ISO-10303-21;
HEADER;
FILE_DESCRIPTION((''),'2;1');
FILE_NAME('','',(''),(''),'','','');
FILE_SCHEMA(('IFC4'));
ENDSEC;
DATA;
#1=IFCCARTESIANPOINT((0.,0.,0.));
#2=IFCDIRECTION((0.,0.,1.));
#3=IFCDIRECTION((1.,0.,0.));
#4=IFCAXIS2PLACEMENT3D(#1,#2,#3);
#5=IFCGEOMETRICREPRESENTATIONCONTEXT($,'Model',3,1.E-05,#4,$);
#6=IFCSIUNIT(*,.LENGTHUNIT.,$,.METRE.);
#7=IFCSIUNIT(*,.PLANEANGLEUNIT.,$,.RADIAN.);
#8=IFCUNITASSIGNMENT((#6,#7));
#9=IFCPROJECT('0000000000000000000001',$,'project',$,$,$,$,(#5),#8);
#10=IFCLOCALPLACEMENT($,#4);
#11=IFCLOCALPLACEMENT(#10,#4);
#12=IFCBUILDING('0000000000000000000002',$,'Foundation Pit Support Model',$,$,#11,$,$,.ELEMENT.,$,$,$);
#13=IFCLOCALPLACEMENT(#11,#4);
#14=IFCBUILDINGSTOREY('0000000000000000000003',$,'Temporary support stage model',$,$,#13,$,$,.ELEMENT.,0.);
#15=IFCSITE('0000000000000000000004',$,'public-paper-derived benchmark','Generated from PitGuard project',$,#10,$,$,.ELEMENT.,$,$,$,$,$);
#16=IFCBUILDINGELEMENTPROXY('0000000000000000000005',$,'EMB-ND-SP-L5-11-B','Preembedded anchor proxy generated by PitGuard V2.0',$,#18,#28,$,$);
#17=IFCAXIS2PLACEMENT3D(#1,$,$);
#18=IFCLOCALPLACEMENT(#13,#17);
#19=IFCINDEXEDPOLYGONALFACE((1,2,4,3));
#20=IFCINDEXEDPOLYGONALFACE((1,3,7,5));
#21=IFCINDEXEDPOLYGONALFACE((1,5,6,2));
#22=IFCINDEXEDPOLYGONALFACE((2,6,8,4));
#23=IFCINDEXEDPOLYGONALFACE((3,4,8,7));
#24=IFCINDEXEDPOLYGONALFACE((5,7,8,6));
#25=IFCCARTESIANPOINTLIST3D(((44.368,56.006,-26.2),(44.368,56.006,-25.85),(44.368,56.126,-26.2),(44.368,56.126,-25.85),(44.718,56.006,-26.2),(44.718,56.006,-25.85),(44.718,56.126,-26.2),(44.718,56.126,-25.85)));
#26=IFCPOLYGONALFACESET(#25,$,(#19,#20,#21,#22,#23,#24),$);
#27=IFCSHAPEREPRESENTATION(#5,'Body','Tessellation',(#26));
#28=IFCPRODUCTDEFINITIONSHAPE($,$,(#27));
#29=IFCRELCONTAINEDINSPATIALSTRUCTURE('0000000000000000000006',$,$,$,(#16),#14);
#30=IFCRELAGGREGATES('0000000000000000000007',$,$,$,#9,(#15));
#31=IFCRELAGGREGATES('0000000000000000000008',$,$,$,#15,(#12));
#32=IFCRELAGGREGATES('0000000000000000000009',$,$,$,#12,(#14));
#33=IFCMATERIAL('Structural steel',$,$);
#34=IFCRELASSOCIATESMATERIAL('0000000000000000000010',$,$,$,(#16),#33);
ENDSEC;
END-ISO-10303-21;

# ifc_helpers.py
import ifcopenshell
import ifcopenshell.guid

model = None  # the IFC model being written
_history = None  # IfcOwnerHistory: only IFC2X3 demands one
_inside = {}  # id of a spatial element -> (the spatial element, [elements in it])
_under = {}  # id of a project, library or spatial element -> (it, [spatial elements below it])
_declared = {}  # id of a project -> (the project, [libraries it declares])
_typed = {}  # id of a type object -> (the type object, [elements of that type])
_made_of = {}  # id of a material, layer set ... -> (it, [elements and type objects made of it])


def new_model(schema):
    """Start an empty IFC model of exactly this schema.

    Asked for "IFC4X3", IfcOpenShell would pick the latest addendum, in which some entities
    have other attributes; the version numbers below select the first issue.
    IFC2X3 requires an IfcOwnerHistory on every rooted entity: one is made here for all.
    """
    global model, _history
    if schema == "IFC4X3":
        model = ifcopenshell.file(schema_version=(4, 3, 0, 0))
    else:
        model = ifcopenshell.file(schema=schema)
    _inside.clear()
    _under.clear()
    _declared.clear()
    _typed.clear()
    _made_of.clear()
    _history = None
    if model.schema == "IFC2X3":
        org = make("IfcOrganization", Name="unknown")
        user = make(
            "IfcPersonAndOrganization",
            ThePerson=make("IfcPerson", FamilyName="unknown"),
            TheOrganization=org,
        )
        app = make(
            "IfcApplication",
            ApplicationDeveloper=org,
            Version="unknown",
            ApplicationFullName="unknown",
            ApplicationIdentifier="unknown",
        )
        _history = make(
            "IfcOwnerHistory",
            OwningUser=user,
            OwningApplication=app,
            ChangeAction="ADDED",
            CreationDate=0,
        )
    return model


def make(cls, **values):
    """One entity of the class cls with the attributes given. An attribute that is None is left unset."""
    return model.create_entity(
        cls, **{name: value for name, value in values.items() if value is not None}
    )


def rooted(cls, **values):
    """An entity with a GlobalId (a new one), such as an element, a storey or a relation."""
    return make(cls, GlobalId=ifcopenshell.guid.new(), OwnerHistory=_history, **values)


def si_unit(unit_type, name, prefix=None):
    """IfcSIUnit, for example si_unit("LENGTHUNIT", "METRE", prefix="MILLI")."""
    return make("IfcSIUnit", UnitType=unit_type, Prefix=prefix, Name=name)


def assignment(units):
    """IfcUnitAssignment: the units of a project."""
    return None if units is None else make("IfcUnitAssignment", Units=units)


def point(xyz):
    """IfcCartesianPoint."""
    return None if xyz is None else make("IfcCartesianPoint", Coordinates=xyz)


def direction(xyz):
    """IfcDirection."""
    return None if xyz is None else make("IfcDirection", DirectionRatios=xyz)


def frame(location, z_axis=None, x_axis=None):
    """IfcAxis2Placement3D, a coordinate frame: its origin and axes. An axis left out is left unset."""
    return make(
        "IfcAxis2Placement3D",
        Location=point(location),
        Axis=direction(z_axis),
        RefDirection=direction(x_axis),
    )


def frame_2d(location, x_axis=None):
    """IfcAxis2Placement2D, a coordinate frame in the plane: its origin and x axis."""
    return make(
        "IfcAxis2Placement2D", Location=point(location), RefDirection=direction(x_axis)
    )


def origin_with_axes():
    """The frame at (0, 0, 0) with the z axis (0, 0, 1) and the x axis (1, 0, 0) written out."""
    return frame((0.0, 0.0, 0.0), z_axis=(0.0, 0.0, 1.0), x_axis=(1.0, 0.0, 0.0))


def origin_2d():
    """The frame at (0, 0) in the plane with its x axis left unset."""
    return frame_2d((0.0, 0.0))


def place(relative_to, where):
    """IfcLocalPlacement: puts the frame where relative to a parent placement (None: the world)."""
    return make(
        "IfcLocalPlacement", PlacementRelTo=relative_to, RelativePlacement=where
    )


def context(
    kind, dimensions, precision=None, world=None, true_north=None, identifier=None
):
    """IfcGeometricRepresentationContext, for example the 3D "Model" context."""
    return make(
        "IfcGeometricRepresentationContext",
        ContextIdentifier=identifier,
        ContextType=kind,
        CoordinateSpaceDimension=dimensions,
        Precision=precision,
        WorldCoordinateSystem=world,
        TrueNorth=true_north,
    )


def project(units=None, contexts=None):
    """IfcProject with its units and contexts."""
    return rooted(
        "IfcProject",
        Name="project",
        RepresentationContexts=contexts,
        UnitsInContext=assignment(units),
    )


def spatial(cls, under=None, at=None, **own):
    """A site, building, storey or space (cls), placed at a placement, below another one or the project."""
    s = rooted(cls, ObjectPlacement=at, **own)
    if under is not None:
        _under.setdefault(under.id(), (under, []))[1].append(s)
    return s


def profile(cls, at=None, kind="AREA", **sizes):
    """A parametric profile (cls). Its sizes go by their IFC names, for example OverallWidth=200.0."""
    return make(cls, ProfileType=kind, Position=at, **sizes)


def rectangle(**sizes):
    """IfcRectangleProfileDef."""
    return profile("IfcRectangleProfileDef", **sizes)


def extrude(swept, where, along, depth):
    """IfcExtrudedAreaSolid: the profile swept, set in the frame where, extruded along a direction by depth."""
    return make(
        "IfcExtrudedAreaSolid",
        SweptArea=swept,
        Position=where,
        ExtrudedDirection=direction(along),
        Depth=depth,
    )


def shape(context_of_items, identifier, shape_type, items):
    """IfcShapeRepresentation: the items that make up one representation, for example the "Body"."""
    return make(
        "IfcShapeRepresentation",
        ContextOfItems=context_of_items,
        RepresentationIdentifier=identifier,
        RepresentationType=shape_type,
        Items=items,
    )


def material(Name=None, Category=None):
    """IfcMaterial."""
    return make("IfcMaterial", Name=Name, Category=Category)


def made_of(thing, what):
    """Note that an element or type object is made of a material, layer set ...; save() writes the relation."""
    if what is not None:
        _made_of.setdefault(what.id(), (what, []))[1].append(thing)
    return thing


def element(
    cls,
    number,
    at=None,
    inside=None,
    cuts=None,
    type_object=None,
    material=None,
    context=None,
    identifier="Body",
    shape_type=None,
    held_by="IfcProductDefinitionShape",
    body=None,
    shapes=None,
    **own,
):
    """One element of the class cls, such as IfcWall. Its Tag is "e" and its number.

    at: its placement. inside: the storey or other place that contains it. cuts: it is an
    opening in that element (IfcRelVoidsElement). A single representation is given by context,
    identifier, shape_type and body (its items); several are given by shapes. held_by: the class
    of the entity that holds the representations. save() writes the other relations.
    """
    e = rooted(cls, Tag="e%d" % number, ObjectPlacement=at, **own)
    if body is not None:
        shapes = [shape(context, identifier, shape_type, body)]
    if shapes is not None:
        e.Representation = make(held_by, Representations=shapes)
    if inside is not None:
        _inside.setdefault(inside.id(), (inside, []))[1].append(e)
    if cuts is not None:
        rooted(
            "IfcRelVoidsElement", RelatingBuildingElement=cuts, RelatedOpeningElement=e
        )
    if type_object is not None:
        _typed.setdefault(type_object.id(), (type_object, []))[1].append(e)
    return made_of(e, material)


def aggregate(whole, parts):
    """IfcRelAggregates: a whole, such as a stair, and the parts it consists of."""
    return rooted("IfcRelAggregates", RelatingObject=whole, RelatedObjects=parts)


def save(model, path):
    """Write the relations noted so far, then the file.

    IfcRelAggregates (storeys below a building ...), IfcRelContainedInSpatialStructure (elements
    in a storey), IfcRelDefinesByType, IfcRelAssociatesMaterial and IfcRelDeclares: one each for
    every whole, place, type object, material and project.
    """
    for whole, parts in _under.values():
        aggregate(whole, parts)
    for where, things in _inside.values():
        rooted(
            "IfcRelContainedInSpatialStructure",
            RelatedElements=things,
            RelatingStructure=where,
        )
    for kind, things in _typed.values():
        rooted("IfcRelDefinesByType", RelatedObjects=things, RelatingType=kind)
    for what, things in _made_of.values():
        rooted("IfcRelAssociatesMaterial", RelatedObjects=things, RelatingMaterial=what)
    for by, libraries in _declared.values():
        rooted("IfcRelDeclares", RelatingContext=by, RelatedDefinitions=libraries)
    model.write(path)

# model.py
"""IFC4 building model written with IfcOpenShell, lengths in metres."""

from ifc_helpers import new_model, si_unit, frame, origin_with_axes, origin_2d, place, context, project, spatial, rectangle, extrude, material, element, save


model = new_model("IFC4")

# Units and contexts
model_context = context("Model", 3, precision=1e-05, world=origin_with_axes())
ifc_project = project(units=[si_unit("LENGTHUNIT", "METRE"), si_unit("PLANEANGLEUNIT", "RADIAN")], contexts=[model_context])

# Site, building, storey
site_placement = place(None, origin_with_axes())
site = spatial("IfcSite", under=ifc_project, at=site_placement, Name="public-paper-derived benchmark", Description="Generated from PitGuard project", CompositionType="ELEMENT")
building_placement = place(site_placement, origin_with_axes())
building = spatial("IfcBuilding", under=site, at=building_placement, Name="Foundation Pit Support Model", CompositionType="ELEMENT")
storey_placement = place(building_placement, origin_with_axes())
storey = spatial("IfcBuildingStorey", under=building, at=storey_placement, Name="Temporary support stage model", CompositionType="ELEMENT", Elevation=0.0)

# Shared definitions
ifc_material_1 = material(Name="Structural steel")

# Building element proxy
proxy_1_placement = place(storey_placement, frame((44.543, 56.066, -26.2), z_axis=(0.0, 0.0, 1.0), x_axis=(1.0, 0.0, 0.0)))
element("IfcBuildingElementProxy", 1, at=proxy_1_placement, inside=storey, material=ifc_material_1, Name="EMB-ND-SP-L5-11-B", Description="Preembedded anchor proxy generated by PitGuard V2.0", context=model_context, shape_type="SweptSolid", body=[
    extrude(rectangle(XDim=0.35, YDim=0.12, at=origin_2d()), origin_with_axes(), (0.0, 0.0, 1.0), 0.35),
])

save(model, "model.ifc")
